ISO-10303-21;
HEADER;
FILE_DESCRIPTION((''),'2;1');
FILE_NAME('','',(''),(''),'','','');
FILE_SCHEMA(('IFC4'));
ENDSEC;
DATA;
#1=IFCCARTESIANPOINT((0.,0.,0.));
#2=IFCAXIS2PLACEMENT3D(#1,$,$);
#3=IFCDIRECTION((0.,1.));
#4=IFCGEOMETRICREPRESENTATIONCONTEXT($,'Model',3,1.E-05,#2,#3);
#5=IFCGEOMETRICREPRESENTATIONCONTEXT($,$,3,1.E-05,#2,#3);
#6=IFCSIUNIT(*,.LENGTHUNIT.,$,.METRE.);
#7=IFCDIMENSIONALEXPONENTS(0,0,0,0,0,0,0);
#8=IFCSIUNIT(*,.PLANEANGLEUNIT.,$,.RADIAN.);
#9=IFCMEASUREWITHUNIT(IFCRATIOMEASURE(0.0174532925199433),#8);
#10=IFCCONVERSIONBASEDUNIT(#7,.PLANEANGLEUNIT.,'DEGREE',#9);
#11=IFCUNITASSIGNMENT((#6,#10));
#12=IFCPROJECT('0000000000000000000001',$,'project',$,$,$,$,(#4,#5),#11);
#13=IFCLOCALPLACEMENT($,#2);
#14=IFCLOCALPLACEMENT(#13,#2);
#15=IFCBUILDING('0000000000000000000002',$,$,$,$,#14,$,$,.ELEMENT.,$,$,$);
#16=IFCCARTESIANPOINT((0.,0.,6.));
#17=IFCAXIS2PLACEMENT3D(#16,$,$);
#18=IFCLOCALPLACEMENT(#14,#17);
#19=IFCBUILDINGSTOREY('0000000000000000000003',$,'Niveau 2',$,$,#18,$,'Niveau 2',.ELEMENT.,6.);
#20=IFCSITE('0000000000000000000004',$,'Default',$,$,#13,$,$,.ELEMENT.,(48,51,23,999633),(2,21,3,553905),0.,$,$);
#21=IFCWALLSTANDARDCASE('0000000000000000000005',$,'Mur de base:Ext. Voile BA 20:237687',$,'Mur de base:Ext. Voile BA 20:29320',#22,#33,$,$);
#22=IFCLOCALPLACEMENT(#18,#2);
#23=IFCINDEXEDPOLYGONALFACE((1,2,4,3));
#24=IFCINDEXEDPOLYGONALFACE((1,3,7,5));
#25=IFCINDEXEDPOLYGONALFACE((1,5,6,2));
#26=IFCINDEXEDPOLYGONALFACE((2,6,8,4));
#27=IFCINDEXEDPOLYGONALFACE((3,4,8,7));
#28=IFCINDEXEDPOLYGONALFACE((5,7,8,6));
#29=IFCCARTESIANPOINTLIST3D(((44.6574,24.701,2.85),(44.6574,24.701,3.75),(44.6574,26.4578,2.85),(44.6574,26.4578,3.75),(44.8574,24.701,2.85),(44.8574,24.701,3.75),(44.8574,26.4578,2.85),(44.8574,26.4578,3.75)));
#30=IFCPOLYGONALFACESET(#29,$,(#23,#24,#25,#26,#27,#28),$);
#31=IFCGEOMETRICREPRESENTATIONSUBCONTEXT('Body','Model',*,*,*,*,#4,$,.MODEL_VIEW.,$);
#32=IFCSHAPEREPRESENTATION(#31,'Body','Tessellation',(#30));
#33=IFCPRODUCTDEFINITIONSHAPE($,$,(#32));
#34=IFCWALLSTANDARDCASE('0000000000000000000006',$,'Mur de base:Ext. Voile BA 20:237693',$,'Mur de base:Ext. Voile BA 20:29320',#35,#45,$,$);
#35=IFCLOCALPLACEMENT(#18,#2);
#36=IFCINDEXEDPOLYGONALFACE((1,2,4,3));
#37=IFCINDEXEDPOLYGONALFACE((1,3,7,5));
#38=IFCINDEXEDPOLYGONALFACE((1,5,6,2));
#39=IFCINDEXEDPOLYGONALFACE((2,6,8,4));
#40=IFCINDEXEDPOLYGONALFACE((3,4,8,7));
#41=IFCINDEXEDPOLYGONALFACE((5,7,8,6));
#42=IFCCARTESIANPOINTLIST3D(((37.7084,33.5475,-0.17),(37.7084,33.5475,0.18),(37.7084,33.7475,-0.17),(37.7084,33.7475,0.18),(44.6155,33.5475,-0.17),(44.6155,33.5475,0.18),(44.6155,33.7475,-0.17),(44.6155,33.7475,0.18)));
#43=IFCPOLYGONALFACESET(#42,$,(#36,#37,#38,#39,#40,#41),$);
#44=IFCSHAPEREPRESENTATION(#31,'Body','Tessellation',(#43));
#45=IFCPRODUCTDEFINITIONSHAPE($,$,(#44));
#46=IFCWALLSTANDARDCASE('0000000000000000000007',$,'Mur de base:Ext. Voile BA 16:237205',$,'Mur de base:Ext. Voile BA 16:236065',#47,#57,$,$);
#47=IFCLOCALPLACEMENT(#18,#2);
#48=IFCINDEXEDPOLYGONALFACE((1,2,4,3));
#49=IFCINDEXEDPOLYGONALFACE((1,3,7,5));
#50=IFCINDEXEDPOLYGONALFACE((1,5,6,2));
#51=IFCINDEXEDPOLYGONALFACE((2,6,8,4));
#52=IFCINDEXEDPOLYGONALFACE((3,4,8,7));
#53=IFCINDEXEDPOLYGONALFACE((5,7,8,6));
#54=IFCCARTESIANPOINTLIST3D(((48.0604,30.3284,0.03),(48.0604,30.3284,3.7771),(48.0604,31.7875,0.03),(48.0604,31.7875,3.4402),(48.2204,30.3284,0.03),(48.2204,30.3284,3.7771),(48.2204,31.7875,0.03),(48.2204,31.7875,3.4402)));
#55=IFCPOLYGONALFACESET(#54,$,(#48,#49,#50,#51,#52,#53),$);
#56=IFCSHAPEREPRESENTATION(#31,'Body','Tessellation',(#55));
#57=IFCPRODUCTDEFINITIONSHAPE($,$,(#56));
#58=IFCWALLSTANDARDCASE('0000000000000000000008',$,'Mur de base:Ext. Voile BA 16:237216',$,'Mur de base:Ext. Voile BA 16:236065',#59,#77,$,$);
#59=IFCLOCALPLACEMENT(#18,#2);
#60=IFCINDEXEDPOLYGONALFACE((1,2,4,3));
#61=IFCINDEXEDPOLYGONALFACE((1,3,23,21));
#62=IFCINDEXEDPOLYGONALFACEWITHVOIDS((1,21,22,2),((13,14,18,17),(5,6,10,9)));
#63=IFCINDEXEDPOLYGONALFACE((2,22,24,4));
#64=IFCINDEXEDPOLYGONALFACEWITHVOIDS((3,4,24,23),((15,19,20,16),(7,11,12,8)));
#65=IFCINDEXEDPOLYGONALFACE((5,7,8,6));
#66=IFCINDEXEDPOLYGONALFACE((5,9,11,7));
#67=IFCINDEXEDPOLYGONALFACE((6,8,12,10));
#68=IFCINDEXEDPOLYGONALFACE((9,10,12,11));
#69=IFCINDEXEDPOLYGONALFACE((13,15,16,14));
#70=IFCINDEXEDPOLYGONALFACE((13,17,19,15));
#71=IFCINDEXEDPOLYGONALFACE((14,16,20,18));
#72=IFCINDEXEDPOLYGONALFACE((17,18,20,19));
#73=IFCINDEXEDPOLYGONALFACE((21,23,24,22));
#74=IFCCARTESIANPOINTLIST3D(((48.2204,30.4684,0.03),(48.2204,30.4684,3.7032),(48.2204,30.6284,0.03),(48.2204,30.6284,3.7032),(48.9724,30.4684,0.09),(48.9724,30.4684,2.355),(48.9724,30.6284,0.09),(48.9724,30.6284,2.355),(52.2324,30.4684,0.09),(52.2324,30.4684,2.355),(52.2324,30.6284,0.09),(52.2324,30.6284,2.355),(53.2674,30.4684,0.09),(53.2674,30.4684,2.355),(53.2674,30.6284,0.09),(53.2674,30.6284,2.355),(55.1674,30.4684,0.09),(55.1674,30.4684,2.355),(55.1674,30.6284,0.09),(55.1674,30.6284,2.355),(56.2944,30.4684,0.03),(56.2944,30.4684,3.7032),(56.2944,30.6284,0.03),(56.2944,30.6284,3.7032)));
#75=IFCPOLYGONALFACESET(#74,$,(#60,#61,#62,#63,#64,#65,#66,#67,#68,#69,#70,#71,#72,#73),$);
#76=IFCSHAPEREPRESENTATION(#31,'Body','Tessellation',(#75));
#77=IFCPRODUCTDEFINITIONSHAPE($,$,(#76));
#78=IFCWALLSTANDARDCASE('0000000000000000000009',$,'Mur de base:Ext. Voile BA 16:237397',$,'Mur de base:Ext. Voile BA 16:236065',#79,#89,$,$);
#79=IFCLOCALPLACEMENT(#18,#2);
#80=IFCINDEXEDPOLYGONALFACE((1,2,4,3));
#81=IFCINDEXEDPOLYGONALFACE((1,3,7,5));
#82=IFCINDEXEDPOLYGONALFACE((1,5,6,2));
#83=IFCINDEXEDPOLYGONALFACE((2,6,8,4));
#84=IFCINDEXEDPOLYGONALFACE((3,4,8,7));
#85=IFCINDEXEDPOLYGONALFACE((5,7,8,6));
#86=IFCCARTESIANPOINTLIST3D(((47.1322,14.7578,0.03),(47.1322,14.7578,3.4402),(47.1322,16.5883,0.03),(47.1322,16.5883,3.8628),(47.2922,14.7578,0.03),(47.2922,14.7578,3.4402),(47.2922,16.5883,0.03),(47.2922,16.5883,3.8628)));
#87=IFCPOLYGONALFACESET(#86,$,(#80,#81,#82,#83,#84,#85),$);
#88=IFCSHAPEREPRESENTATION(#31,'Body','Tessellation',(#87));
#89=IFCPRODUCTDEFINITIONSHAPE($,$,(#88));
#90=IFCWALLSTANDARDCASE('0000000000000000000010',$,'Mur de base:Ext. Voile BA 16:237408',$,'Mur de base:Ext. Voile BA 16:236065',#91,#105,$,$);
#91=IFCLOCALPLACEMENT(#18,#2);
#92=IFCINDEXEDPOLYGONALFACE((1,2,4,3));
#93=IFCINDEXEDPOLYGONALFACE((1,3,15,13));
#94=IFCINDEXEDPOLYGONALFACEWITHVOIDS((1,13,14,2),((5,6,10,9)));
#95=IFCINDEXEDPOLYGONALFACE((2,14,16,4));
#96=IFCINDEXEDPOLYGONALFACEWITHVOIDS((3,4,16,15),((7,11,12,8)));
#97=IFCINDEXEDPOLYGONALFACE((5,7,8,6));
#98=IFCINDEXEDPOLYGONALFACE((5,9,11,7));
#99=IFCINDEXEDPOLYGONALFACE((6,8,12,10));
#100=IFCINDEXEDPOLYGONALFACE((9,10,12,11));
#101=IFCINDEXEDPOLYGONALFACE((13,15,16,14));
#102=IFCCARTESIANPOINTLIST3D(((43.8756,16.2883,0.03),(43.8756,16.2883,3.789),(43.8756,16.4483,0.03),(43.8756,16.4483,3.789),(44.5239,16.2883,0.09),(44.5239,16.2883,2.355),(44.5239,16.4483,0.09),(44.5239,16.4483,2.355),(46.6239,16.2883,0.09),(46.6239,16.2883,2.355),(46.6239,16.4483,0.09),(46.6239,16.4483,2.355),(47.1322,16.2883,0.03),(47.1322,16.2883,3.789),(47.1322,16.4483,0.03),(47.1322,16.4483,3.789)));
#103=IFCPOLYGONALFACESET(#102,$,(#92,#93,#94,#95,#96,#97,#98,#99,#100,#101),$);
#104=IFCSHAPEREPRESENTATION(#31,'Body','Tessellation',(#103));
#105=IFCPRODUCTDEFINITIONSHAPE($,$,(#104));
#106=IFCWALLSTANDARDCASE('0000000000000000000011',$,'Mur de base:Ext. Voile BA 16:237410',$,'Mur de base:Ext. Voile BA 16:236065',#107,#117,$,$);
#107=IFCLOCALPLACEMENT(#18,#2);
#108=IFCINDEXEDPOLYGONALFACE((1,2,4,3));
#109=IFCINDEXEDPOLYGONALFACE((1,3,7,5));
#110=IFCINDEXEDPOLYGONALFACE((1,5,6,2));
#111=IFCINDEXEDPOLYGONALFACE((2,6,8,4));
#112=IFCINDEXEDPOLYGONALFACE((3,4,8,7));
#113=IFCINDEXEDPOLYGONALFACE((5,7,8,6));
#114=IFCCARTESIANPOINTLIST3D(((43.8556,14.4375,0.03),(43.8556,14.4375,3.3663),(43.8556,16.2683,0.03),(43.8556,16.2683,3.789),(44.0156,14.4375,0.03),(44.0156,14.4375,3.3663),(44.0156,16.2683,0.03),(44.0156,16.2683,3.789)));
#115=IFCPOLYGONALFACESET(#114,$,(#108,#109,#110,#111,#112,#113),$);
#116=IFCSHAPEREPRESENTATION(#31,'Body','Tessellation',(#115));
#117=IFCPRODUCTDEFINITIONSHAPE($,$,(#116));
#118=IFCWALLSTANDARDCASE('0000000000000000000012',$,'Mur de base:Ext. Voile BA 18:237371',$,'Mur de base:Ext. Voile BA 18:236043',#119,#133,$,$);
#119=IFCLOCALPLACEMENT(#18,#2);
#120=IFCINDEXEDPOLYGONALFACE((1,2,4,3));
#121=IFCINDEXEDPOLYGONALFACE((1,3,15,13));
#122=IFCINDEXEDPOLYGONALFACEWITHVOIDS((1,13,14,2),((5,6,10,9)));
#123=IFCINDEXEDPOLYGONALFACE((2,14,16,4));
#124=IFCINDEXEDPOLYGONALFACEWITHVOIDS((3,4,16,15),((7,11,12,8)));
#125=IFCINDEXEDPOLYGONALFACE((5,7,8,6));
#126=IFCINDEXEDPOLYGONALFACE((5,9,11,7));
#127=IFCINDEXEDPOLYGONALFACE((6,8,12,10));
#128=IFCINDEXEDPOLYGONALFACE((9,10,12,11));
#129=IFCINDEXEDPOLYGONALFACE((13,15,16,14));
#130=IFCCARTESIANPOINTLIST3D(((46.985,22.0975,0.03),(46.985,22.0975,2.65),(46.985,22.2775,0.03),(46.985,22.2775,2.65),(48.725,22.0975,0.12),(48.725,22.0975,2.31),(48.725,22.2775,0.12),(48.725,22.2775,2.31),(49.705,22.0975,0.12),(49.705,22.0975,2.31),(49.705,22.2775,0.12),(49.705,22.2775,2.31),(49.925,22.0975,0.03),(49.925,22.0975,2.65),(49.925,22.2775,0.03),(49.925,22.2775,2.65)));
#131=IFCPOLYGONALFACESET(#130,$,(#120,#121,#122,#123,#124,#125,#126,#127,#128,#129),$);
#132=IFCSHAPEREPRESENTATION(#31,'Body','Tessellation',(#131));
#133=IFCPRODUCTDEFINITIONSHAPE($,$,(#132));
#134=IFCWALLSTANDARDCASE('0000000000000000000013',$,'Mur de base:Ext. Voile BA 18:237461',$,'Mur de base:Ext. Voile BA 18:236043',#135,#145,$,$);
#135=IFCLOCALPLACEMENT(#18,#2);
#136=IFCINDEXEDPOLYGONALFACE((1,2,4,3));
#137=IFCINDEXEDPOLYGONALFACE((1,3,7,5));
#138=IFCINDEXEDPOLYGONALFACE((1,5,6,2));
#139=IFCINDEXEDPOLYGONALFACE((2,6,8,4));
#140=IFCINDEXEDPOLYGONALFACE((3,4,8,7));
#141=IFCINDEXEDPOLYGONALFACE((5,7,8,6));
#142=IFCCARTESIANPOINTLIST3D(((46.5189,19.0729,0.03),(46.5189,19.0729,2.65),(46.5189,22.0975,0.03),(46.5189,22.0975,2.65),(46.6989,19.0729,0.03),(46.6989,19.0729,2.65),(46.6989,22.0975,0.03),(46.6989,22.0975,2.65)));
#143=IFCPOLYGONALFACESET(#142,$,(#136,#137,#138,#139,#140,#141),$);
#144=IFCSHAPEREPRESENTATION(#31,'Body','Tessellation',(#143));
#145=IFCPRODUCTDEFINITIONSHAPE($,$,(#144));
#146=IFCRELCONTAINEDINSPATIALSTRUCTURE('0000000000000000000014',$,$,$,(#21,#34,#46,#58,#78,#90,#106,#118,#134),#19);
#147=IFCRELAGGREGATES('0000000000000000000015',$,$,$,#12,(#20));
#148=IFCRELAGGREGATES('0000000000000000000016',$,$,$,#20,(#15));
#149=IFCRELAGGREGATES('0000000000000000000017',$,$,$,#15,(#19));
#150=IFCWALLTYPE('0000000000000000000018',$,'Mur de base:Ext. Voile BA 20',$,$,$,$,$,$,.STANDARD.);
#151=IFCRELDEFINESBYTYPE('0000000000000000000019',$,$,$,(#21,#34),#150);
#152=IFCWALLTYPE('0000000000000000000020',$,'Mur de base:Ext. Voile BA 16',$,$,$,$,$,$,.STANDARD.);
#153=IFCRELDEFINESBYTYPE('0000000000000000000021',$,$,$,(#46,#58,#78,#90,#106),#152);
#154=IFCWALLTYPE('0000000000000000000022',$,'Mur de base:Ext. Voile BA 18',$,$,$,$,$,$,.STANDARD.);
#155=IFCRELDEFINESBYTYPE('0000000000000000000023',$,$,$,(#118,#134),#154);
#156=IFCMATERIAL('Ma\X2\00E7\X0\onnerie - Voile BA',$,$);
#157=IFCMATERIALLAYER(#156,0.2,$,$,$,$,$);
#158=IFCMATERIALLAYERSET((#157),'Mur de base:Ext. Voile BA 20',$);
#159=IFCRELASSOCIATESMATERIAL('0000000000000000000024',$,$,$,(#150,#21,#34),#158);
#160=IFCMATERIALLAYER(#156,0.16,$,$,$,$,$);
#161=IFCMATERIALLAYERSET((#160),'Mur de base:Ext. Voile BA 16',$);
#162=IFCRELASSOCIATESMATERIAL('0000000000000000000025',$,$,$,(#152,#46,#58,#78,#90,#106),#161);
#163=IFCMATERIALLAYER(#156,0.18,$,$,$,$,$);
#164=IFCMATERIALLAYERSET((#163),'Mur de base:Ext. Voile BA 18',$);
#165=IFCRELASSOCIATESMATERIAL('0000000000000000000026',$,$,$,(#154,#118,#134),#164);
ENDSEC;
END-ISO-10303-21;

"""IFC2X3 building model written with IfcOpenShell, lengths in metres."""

from ifc_helpers import new_model, entity, si_unit, converted_unit, direction, frame, frame_2d, origin, origin_2d_with_axis, place, context, subcontext, project, spatial, rectangle, extrude, clip, halfspace, material, layer, layer_set, layer_usage, type_object, element, save


model = new_model("IFC2X3")

# Units and contexts
model_context = context("Model", 3, precision=1e-05, world=origin(), true_north=direction((0.0, 1.0)))
context_of_model = context(None, 3, precision=1e-05, world=origin(), true_north=direction((0.0, 1.0)))
body_context = subcontext(model_context, "Body", "Model", "MODEL_VIEW")
ifc_project = project(units=[si_unit("LENGTHUNIT", "METRE"), converted_unit("PLANEANGLEUNIT", "DEGREE", entity("IfcRatioMeasure", 0.0174532925199433), si_unit("PLANEANGLEUNIT", "RADIAN"), dimensions=[0, 0, 0, 0, 0, 0, 0])], contexts=[model_context, context_of_model])

# Site, building, storey
site_placement = place(None, origin())
site = spatial("IfcSite", under=ifc_project, at=site_placement, Name="Default", CompositionType="ELEMENT", RefLatitude=(48, 51, 23, 999633), RefLongitude=(2, 21, 3, 553905), RefElevation=0.0)
building_placement = place(site_placement, origin())
building = spatial("IfcBuilding", under=site, at=building_placement, CompositionType="ELEMENT")
storey_placement = place(building_placement, frame((0.0, 0.0, 6.0)))
storey = spatial("IfcBuildingStorey", under=building, at=storey_placement, Name="Niveau 2", LongName="Niveau 2", CompositionType="ELEMENT", Elevation=6.0)

# Shared definitions
ifc_material = material(Name="Maçonnerie - Voile BA")
ifc_layer_1 = layer(ifc_material, 0.2)
ifc_layer_set_1 = layer_set([ifc_layer_1], Name="Mur de base:Ext. Voile BA 20")
wall_type_1 = type_object("IfcWallType", Name="Mur de base:Ext. Voile BA 20", PredefinedType="STANDARD", material=ifc_layer_set_1)

# Walls
ifc_layer_usage_1 = layer_usage(ifc_layer_set_1, "AXIS2", "NEGATIVE", 0.1)
wall_1_placement = place(storey_placement, frame((44.7574, 24.701, 2.85), z_axis=(0.0, 0.0, 1.0), x_axis=(0.0, 1.0, 0.0)))
element("IfcWallStandardCase", 1, at=wall_1_placement, inside=storey, type_object=wall_type_1, material=ifc_layer_usage_1, Name="Mur de base:Ext. Voile BA 20:237687", ObjectType="Mur de base:Ext. Voile BA 20:29320", context=body_context, shape_type="SweptSolid", body=[
    extrude(rectangle(XDim=1.7568, YDim=0.2, at=frame_2d((0.8784, 0.0), x_axis=(-1.0, 0.0))), origin(), (0.0, 0.0, 1.0), 0.9),
])
ifc_layer_usage_2 = layer_usage(ifc_layer_set_1, "AXIS2", "POSITIVE", -0.1)
wall_2_placement = place(storey_placement, frame((44.6155, 33.6475, -0.17), z_axis=(0.0, 0.0, 1.0), x_axis=(-1.0, 0.0, 0.0)))
element("IfcWallStandardCase", 2, at=wall_2_placement, inside=storey, type_object=wall_type_1, material=ifc_layer_usage_2, Name="Mur de base:Ext. Voile BA 20:237693", ObjectType="Mur de base:Ext. Voile BA 20:29320", context=body_context, shape_type="SweptSolid", body=[
    extrude(rectangle(XDim=6.9071, YDim=0.2, at=frame_2d((3.4536, 0.0), x_axis=(-1.0, 0.0))), origin(), (0.0, 0.0, 1.0), 0.35),
])
ifc_layer_2 = layer(ifc_material, 0.16)
ifc_layer_set_2 = layer_set([ifc_layer_2], Name="Mur de base:Ext. Voile BA 16")
ifc_layer_usage_3 = layer_usage(ifc_layer_set_2, "AXIS2", "NEGATIVE", 0.08)
wall_type_2 = type_object("IfcWallType", Name="Mur de base:Ext. Voile BA 16", PredefinedType="STANDARD", material=ifc_layer_set_2)
wall_3_placement = place(storey_placement, frame((48.1404, 31.7875, 0.03), z_axis=(0.0, 0.0, 1.0), x_axis=(0.0, -1.0, 0.0)))
element("IfcWallStandardCase", 3, at=wall_3_placement, inside=storey, type_object=wall_type_2, material=ifc_layer_usage_3, Name="Mur de base:Ext. Voile BA 16:237205", ObjectType="Mur de base:Ext. Voile BA 16:236065", context=body_context, shape_type="Clipping", body=[
    clip(extrude(rectangle(XDim=1.4591, YDim=0.16, at=frame_2d((0.7295, 0.0), x_axis=(-1.0, 0.0))), origin(), (0.0, 0.0, 1.0), 3.7471), halfspace(frame((0.0, -0.08, 3.4102), z_axis=(-0.224951, 0.0, 0.97437), x_axis=(0.0, 1.0, 0.0)), False)),
])

# Wall, openings
ifc_layer_usage_4 = layer_usage(ifc_layer_set_2, "AXIS2", "NEGATIVE", 0.08)
wall_4_placement = place(storey_placement, frame((48.2204, 30.5484, 0.03)))
wall_4 = element("IfcWallStandardCase", 4, at=wall_4_placement, inside=storey, type_object=wall_type_2, material=ifc_layer_usage_4, Name="Mur de base:Ext. Voile BA 16:237216", ObjectType="Mur de base:Ext. Voile BA 16:236065", context=body_context, shape_type="SweptSolid", body=[
    extrude(rectangle(XDim=8.074, YDim=0.16, at=frame_2d((4.037, 0.0), x_axis=(-1.0, 0.0))), origin(), (0.0, 0.0, 1.0), 3.6732),
])
opening_1_placement = place(wall_4_placement, origin())
element("IfcOpeningElement", 5, at=opening_1_placement, cuts=wall_4, ObjectType="Opening", context=body_context, shape_type="SweptSolid", body=[
    extrude(rectangle(XDim=2.265, YDim=3.26, at=origin_2d_with_axis()), frame((2.382, -0.08, 1.1925), z_axis=(0.0, 1.0, 0.0), x_axis=(0.0, 0.0, -1.0)), (0.0, 0.0, 1.0), 0.16),
])
opening_2_placement = place(wall_4_placement, origin())
element("IfcOpeningElement", 6, at=opening_2_placement, cuts=wall_4, ObjectType="Opening", context=body_context, shape_type="SweptSolid", body=[
    extrude(rectangle(XDim=2.265, YDim=1.9, at=frame_2d((0.0, 0.0), x_axis=(1.0, 0.0))), frame((5.997, -0.08, 1.1925), z_axis=(0.0, 1.0, 0.0), x_axis=(0.0, 0.0, -1.0)), (0.0, 0.0, 1.0), 0.16),
])

# Wall
ifc_layer_usage_5 = layer_usage(ifc_layer_set_2, "AXIS2", "NEGATIVE", 0.08)
wall_5_placement = place(storey_placement, frame((47.2122, 14.7578, 0.03), z_axis=(0.0, 0.0, 1.0), x_axis=(0.0, 1.0, 0.0)))
element("IfcWallStandardCase", 7, at=wall_5_placement, inside=storey, type_object=wall_type_2, material=ifc_layer_usage_5, Name="Mur de base:Ext. Voile BA 16:237397", ObjectType="Mur de base:Ext. Voile BA 16:236065", context=body_context, shape_type="Clipping", body=[
    clip(extrude(rectangle(XDim=1.8304, YDim=0.16, at=frame_2d((0.9152, 0.0), x_axis=(-1.0, 0.0))), origin(), (0.0, 0.0, 1.0), 3.8328), halfspace(frame((0.0, -0.08, 3.4102), z_axis=(-0.224951, 0.0, 0.97437), x_axis=(0.0, 1.0, 0.0)), False)),
])

# Wall, opening
ifc_layer_usage_6 = layer_usage(ifc_layer_set_2, "AXIS2", "NEGATIVE", 0.08)
wall_6_placement = place(storey_placement, frame((47.1322, 16.3683, 0.03), z_axis=(0.0, 0.0, 1.0), x_axis=(-1.0, 0.0, 0.0)))
wall_6 = element("IfcWallStandardCase", 8, at=wall_6_placement, inside=storey, type_object=wall_type_2, material=ifc_layer_usage_6, Name="Mur de base:Ext. Voile BA 16:237408", ObjectType="Mur de base:Ext. Voile BA 16:236065", context=body_context, shape_type="SweptSolid", body=[
    extrude(rectangle(XDim=3.2567, YDim=0.16, at=frame_2d((1.6283, 0.0), x_axis=(-1.0, 0.0))), origin(), (0.0, 0.0, 1.0), 3.759),
])
opening_3_placement = place(wall_6_placement, origin())
element("IfcOpeningElement", 9, at=opening_3_placement, cuts=wall_6, ObjectType="Opening", context=body_context, shape_type="SweptSolid", body=[
    extrude(rectangle(XDim=2.265, YDim=2.1, at=frame_2d((0.0, 0.0), x_axis=(1.0, 0.0))), frame((1.5583, -0.08, 1.1925), z_axis=(0.0, 1.0, 0.0), x_axis=(0.0, 0.0, -1.0)), (0.0, 0.0, 1.0), 0.16),
])

# Wall
ifc_layer_usage_7 = layer_usage(ifc_layer_set_2, "AXIS2", "NEGATIVE", 0.08)
wall_7_placement = place(storey_placement, frame((43.9356, 16.2683, 0.03), z_axis=(0.0, 0.0, 1.0), x_axis=(0.0, -1.0, 0.0)))
element("IfcWallStandardCase", 10, at=wall_7_placement, inside=storey, type_object=wall_type_2, material=ifc_layer_usage_7, Name="Mur de base:Ext. Voile BA 16:237410", ObjectType="Mur de base:Ext. Voile BA 16:236065", context=body_context, shape_type="Clipping", body=[
    clip(extrude(rectangle(XDim=1.8308, YDim=0.16, at=frame_2d((0.9154, 0.0), x_axis=(-1.0, 0.0))), origin(), (0.0, 0.0, 1.0), 3.759), halfspace(frame((0.0, -0.08, 3.759), z_axis=(0.224951, 0.0, 0.97437), x_axis=(0.0, 1.0, 0.0)), False)),
])

# Wall, opening
ifc_layer_3 = layer(ifc_material, 0.18)
ifc_layer_set_3 = layer_set([ifc_layer_3], Name="Mur de base:Ext. Voile BA 18")
ifc_layer_usage_8 = layer_usage(ifc_layer_set_3, "AXIS2", "NEGATIVE", 0.09)
wall_type_3 = type_object("IfcWallType", Name="Mur de base:Ext. Voile BA 18", PredefinedType="STANDARD", material=ifc_layer_set_3)
wall_8_placement = place(storey_placement, frame((46.985, 22.1875, 0.03)))
wall_8 = element("IfcWallStandardCase", 11, at=wall_8_placement, inside=storey, type_object=wall_type_3, material=ifc_layer_usage_8, Name="Mur de base:Ext. Voile BA 18:237371", ObjectType="Mur de base:Ext. Voile BA 18:236043", context=body_context, shape_type="SweptSolid", body=[
    extrude(rectangle(XDim=2.94, YDim=0.18, at=frame_2d((1.47, 0.0), x_axis=(-1.0, 0.0))), origin(), (0.0, 0.0, 1.0), 2.62),
])
opening_4_placement = place(wall_8_placement, origin())
element("IfcOpeningElement", 12, at=opening_4_placement, cuts=wall_8, ObjectType="Opening", context=body_context, shape_type="SweptSolid", body=[
    extrude(rectangle(XDim=2.19, YDim=0.98, at=frame_2d((0.0, 0.0), x_axis=(1.0, 0.0))), frame((2.23, -0.09, 1.185), z_axis=(0.0, 1.0, 0.0), x_axis=(0.0, 0.0, -1.0)), (0.0, 0.0, 1.0), 0.18),
])

# Wall
ifc_layer_usage_9 = layer_usage(ifc_layer_set_3, "AXIS2", "POSITIVE", -0.09)
wall_9_placement = place(storey_placement, frame((46.6089, 19.0729, 0.03), z_axis=(0.0, 0.0, 1.0), x_axis=(0.0, 1.0, 0.0)))
element("IfcWallStandardCase", 13, at=wall_9_placement, inside=storey, type_object=wall_type_3, material=ifc_layer_usage_9, Name="Mur de base:Ext. Voile BA 18:237461", ObjectType="Mur de base:Ext. Voile BA 18:236043", context=body_context, shape_type="SweptSolid", body=[
    extrude(rectangle(XDim=3.0246, YDim=0.18, at=frame_2d((1.5123, 0.0), x_axis=(-1.0, 0.0))), origin(), (0.0, 0.0, 1.0), 2.62),
])

save(model, "model.ifc")
